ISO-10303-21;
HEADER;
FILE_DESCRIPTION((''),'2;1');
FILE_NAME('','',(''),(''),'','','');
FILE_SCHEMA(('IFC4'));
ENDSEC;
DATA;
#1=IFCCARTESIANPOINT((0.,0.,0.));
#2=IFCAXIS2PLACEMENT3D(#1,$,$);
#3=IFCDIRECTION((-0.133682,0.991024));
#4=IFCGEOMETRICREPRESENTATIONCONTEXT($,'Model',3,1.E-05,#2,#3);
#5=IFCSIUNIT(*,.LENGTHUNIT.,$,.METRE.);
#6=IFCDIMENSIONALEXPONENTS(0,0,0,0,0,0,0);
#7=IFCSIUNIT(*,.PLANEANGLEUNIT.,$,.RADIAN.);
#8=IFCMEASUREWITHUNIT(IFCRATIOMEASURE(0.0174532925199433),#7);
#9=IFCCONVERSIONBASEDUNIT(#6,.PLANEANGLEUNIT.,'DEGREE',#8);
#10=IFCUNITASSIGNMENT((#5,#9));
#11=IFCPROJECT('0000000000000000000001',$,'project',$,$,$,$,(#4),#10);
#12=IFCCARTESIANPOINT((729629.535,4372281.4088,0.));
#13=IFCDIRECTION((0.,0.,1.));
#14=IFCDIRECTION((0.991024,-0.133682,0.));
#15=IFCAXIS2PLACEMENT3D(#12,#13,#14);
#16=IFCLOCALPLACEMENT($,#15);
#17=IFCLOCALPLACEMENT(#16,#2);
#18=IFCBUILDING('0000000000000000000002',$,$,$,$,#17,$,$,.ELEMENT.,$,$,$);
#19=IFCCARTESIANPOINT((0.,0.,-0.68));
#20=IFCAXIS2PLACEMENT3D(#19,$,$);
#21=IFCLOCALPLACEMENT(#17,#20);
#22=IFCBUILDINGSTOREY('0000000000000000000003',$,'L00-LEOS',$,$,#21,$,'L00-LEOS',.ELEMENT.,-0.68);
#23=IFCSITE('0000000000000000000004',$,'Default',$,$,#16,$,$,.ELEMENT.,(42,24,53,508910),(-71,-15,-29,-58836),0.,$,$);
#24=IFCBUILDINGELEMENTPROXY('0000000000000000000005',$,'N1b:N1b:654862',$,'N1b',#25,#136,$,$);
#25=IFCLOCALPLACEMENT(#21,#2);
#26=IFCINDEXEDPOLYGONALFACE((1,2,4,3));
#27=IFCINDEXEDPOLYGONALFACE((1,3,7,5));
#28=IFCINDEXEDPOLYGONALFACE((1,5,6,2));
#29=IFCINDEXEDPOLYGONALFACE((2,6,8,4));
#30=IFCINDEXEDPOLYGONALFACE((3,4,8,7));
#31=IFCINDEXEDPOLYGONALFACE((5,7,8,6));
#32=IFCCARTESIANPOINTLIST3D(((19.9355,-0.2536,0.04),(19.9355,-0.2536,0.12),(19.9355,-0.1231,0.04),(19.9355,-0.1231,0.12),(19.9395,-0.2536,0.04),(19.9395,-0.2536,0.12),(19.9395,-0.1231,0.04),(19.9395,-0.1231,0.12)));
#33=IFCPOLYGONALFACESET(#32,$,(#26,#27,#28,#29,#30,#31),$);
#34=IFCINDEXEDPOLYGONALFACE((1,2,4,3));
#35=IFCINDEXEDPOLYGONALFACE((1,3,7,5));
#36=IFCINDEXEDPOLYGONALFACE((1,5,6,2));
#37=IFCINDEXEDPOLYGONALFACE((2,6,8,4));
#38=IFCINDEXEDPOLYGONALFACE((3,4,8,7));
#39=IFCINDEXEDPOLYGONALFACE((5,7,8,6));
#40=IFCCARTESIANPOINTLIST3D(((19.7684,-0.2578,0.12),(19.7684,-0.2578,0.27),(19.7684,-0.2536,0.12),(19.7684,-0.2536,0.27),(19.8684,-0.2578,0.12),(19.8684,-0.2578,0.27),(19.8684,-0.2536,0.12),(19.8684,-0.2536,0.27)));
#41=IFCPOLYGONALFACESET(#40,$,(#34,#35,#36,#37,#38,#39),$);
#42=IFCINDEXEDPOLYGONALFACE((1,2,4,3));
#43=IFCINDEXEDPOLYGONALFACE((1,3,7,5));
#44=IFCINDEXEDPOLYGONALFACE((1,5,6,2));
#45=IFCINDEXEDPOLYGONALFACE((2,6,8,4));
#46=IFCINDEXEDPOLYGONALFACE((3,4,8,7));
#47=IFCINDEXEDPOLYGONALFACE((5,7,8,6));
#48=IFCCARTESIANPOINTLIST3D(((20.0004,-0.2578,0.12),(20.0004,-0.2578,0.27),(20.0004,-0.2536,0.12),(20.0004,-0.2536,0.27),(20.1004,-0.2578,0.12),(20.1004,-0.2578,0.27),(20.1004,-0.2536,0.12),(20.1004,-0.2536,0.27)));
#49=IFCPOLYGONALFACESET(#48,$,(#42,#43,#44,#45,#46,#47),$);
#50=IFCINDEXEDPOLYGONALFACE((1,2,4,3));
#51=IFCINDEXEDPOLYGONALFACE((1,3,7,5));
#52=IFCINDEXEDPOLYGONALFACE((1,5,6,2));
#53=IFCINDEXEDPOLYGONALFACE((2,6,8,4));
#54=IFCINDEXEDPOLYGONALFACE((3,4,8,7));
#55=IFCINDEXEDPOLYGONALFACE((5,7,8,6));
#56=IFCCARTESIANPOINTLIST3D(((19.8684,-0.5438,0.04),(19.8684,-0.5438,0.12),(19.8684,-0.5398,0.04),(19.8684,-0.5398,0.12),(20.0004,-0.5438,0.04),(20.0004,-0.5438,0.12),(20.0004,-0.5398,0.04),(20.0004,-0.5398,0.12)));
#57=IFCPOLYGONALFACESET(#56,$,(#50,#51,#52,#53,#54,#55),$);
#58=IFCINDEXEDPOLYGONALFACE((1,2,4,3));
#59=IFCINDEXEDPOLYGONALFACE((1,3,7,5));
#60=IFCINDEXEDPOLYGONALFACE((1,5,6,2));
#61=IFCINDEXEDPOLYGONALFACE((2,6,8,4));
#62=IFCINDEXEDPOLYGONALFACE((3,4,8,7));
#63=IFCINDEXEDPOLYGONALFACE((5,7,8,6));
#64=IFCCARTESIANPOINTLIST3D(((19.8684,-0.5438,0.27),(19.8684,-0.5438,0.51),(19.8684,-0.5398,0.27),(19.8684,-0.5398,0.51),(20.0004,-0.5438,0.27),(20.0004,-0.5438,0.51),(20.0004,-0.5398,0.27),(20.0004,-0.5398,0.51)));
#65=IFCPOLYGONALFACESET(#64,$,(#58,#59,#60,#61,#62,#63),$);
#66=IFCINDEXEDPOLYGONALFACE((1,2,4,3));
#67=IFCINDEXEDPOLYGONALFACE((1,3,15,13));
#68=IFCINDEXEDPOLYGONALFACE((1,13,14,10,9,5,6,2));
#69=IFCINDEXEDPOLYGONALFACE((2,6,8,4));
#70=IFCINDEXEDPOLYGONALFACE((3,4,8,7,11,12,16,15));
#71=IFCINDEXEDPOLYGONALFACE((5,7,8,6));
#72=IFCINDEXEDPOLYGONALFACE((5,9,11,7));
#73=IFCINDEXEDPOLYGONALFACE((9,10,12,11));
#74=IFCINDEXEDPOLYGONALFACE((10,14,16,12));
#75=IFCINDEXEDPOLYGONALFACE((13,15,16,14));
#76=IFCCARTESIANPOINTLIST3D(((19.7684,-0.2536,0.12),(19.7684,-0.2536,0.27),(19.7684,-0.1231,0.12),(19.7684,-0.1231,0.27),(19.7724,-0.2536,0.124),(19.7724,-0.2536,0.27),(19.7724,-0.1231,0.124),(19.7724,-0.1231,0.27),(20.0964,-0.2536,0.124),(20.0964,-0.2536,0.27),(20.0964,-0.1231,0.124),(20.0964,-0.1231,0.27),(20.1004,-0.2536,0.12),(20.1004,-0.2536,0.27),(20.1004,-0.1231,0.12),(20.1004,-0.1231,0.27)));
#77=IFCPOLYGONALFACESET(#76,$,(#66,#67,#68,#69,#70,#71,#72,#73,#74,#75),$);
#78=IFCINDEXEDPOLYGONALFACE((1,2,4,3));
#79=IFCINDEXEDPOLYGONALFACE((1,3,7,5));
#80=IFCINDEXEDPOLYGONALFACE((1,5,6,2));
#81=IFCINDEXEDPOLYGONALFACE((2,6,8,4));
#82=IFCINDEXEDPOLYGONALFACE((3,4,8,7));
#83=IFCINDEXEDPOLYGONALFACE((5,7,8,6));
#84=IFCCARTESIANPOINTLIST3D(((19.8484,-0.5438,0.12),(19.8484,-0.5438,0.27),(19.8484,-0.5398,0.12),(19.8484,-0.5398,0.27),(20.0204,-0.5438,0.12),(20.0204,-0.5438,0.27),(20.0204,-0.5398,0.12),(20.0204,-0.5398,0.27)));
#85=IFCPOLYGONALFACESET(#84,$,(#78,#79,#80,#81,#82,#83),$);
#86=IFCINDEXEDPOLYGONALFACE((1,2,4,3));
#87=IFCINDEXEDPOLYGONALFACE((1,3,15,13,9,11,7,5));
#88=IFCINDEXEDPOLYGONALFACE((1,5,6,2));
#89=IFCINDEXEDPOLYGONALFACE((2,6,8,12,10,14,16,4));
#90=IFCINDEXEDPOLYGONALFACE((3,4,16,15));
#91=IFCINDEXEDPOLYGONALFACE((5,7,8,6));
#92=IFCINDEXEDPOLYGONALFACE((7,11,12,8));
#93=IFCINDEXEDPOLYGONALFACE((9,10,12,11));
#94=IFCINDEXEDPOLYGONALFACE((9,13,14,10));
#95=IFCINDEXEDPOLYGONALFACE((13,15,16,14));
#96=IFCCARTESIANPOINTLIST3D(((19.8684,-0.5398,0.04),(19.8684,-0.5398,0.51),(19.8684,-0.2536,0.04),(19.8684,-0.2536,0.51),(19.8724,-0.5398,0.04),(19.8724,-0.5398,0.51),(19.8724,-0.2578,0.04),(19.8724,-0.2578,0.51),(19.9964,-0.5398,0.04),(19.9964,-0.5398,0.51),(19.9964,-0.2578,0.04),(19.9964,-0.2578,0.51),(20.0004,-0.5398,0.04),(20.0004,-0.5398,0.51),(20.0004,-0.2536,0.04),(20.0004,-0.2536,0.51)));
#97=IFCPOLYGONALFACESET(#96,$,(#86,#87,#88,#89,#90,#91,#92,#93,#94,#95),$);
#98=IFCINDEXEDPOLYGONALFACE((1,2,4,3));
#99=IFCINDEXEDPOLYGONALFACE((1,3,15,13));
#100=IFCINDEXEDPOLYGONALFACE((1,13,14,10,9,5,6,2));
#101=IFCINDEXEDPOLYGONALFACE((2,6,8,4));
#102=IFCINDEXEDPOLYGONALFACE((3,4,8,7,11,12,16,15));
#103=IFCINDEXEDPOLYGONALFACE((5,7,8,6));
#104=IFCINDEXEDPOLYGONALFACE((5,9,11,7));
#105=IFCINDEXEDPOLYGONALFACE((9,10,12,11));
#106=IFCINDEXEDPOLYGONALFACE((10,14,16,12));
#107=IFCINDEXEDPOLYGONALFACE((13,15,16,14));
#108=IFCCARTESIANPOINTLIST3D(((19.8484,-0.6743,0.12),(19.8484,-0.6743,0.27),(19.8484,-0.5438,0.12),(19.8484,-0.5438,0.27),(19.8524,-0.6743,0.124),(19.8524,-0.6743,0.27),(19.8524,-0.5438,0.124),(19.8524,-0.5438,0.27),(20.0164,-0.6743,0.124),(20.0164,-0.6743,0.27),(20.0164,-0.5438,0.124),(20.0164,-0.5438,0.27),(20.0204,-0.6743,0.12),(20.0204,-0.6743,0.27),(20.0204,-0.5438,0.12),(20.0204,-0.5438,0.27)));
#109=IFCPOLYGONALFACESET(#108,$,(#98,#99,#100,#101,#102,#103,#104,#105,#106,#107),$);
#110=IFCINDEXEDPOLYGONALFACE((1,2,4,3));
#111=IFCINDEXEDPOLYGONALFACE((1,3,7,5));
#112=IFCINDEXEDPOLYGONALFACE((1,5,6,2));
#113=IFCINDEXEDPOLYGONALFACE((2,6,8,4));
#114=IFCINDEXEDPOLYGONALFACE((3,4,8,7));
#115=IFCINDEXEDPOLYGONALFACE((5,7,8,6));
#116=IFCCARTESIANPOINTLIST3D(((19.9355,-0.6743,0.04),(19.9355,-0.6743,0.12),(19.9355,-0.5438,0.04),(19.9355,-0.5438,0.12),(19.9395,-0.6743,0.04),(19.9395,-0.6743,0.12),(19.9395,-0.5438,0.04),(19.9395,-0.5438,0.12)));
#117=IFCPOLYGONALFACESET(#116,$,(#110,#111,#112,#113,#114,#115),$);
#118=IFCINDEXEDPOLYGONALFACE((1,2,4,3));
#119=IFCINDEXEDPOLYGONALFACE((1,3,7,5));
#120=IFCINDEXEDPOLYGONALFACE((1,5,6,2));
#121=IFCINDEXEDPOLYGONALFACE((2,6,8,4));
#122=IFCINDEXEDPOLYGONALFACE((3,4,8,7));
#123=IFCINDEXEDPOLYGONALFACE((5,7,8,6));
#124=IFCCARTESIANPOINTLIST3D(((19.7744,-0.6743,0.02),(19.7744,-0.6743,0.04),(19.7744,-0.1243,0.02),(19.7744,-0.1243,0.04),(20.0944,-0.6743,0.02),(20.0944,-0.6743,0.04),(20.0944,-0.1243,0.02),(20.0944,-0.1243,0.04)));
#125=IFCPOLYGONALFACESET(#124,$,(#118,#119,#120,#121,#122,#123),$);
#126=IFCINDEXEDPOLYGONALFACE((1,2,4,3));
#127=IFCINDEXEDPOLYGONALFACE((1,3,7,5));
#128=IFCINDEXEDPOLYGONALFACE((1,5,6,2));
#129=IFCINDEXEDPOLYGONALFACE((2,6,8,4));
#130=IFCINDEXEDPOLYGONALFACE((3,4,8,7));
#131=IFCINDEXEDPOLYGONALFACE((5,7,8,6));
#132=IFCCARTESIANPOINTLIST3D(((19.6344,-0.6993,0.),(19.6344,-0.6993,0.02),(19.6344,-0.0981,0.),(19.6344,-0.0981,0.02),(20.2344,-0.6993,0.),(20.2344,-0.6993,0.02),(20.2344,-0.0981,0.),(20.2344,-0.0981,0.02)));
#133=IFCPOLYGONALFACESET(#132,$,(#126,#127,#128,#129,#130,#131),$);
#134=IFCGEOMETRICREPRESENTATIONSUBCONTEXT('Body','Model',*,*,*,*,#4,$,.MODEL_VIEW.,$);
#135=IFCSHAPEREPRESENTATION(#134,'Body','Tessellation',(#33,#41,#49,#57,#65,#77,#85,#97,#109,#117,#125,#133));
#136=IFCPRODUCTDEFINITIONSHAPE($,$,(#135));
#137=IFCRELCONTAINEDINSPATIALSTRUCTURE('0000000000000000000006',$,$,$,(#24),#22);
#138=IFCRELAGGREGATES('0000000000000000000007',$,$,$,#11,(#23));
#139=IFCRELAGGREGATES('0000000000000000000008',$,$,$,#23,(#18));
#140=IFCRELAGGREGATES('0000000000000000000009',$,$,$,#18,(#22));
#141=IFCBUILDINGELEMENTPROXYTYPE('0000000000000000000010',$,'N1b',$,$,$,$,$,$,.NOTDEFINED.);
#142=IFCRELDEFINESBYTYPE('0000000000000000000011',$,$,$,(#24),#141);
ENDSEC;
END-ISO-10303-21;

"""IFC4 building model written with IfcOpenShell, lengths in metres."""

from ifc_helpers import new_model, entity, si_unit, converted_unit, direction, frame, frame_2d, origin, origin_2d_with_axis, place, context, subcontext, project, spatial, polyline, rectangle, outline, extrude, source, transform, mapped, type_object, type_shapes, element, save


model = new_model("IFC4")

# Units and contexts
model_context = context("Model", 3, precision=1e-05, world=origin(), true_north=direction((-0.133682, 0.991024)))
body_context = subcontext(model_context, "Body", "Model", "MODEL_VIEW")
ifc_project = project(units=[si_unit("LENGTHUNIT", "METRE"), converted_unit("PLANEANGLEUNIT", "DEGREE", entity("IfcRatioMeasure", 0.0174532925199433), si_unit("PLANEANGLEUNIT", "RADIAN"), dimensions=[0, 0, 0, 0, 0, 0, 0])], contexts=[model_context])

# Site, building, storey
site_placement = place(None, frame((729629.535, 4372281.4088, 0.0), z_axis=(0.0, 0.0, 1.0), x_axis=(0.991024, -0.133682, 0.0)))
site = spatial("IfcSite", under=ifc_project, at=site_placement, Name="Default", CompositionType="ELEMENT", RefLatitude=(42, 24, 53, 508910), RefLongitude=(-71, -15, -29, -58836), RefElevation=0.0)
building_placement = place(site_placement, origin())
building = spatial("IfcBuilding", under=site, at=building_placement, CompositionType="ELEMENT")
storey_placement = place(building_placement, frame((0.0, 0.0, -0.68)))
storey = spatial("IfcBuildingStorey", under=building, at=storey_placement, Name="L00-LEOS", LongName="L00-LEOS", CompositionType="ELEMENT", Elevation=-0.68)

# Building element proxy
building_element_proxy_type_1 = type_object("IfcBuildingElementProxyType", Name="N1b")
shared_shape_1 = source(origin(), body_context, "Body", "SweptSolid", [
    extrude(rectangle(XDim=0.004, YDim=0.1305, at=origin_2d_with_axis()), frame((0.2103, 0.0, 0.04), z_axis=(0.0, 0.0, 1.0), x_axis=(0.0, -1.0, 0.0)), (0.0, 0.0, 1.0), 0.08),
    extrude(rectangle(XDim=0.1, YDim=0.0042, at=frame_2d((0.0, 0.0), x_axis=(1.0, 0.0))), frame((0.143, 0.1191, 0.12), z_axis=(0.0, 0.0, 1.0), x_axis=(0.0, 1.0, 0.0)), (0.0, 0.0, 1.0), 0.15),
    extrude(rectangle(XDim=0.1, YDim=0.0042, at=origin_2d_with_axis()), frame((0.143, -0.1129, 0.12), z_axis=(0.0, 0.0, 1.0), x_axis=(0.0, 1.0, 0.0)), (0.0, 0.0, 1.0), 0.15),
    extrude(rectangle(XDim=0.132, YDim=0.004, at=frame_2d((0.0, 0.0), x_axis=(1.0, 0.0))), frame((-0.1431, 0.0031, 0.04), z_axis=(0.0, 0.0, 1.0), x_axis=(0.0, 1.0, 0.0)), (0.0, 0.0, 1.0), 0.08),
    extrude(rectangle(XDim=0.132, YDim=0.004, at=frame_2d((0.0, 0.0), x_axis=(1.0, 0.0))), frame((-0.1431, 0.0031, 0.27), z_axis=(0.0, 0.0, 1.0), x_axis=(0.0, 1.0, 0.0)), (0.0, 0.0, 1.0), 0.24),
    extrude(outline(polyline([(-0.076, -0.166), (0.074, -0.166), (0.074, -0.162), (-0.072, -0.162), (-0.072, 0.162), (0.074, 0.162), (0.074, 0.166), (-0.076, 0.166), (-0.076, -0.166)])), frame((0.1451, 0.0031, 0.196), z_axis=(1.0, 0.0, 0.0), x_axis=(0.0, 0.0, 1.0)), (0.0, 0.0, 1.0), 0.1305),
    extrude(rectangle(XDim=0.172, YDim=0.004, at=frame_2d((0.0, 0.0), x_axis=(1.0, 0.0))), frame((-0.1431, 0.0031, 0.12), z_axis=(0.0, 0.0, 1.0), x_axis=(0.0, 1.0, 0.0)), (0.0, 0.0, 1.0), 0.15),
    extrude(outline(polyline([(-0.1441, -0.066), (0.142, -0.066), (0.142, -0.062), (-0.14, -0.062), (-0.14, 0.062), (0.142, 0.062), (0.142, 0.066), (-0.1441, 0.066), (-0.1441, -0.066)])), frame((0.001, 0.0031, 0.04), z_axis=(0.0, 0.0, 1.0), x_axis=(-1.0, 0.0, 0.0)), (0.0, 0.0, 1.0), 0.47),
    extrude(outline(polyline([(-0.076, -0.086), (0.074, -0.086), (0.074, -0.082), (-0.072, -0.082), (-0.072, 0.082), (0.074, 0.082), (0.074, 0.086), (-0.076, 0.086), (-0.076, -0.086)])), frame((-0.2756, 0.0031, 0.196), z_axis=(1.0, 0.0, 0.0), x_axis=(0.0, 0.0, 1.0)), (0.0, 0.0, 1.0), 0.1305),
    extrude(rectangle(XDim=0.004, YDim=0.1305, at=origin_2d_with_axis()), frame((-0.2103, 0.0, 0.04), z_axis=(0.0, 0.0, 1.0), x_axis=(0.0, -1.0, 0.0)), (0.0, 0.0, 1.0), 0.08),
    extrude(rectangle(XDim=0.55, YDim=0.32, at=frame_2d((0.0, 0.0), x_axis=(1.0, 0.0))), frame((-0.0006, 0.0031, 0.02), z_axis=(0.0, 0.0, 1.0), x_axis=(-1.0, 0.0, 0.0)), (0.0, 0.0, 1.0), 0.02),
    extrude(rectangle(XDim=0.6012, YDim=0.6, at=frame_2d((0.0, 0.0), x_axis=(1.0, 0.0))), frame((0.0, 0.0031, 0.0), z_axis=(0.0, 0.0, 1.0), x_axis=(-1.0, 0.0, 0.0)), (0.0, 0.0, 1.0), 0.02),
])
type_shapes(building_element_proxy_type_1, [shared_shape_1])
for number, where, z_axis, x_axis, name in (
    (1, (19.9375, -0.3987, 0.0), (0.0, 0.0, 1.0), (0.0, 1.0, 0.0), "N1b:N1b:654862"),
):
    element("IfcBuildingElementProxy", number, at=place(storey_placement, frame(where, z_axis=z_axis, x_axis=x_axis)), inside=storey, type_object=building_element_proxy_type_1, Name=name, ObjectType="N1b", context=body_context, shape_type="MappedRepresentation", body=[
        mapped(shared_shape_1, transform((0.0, 0.0, 0.0), scale=1.0)),
    ])

save(model, "model.ifc")
